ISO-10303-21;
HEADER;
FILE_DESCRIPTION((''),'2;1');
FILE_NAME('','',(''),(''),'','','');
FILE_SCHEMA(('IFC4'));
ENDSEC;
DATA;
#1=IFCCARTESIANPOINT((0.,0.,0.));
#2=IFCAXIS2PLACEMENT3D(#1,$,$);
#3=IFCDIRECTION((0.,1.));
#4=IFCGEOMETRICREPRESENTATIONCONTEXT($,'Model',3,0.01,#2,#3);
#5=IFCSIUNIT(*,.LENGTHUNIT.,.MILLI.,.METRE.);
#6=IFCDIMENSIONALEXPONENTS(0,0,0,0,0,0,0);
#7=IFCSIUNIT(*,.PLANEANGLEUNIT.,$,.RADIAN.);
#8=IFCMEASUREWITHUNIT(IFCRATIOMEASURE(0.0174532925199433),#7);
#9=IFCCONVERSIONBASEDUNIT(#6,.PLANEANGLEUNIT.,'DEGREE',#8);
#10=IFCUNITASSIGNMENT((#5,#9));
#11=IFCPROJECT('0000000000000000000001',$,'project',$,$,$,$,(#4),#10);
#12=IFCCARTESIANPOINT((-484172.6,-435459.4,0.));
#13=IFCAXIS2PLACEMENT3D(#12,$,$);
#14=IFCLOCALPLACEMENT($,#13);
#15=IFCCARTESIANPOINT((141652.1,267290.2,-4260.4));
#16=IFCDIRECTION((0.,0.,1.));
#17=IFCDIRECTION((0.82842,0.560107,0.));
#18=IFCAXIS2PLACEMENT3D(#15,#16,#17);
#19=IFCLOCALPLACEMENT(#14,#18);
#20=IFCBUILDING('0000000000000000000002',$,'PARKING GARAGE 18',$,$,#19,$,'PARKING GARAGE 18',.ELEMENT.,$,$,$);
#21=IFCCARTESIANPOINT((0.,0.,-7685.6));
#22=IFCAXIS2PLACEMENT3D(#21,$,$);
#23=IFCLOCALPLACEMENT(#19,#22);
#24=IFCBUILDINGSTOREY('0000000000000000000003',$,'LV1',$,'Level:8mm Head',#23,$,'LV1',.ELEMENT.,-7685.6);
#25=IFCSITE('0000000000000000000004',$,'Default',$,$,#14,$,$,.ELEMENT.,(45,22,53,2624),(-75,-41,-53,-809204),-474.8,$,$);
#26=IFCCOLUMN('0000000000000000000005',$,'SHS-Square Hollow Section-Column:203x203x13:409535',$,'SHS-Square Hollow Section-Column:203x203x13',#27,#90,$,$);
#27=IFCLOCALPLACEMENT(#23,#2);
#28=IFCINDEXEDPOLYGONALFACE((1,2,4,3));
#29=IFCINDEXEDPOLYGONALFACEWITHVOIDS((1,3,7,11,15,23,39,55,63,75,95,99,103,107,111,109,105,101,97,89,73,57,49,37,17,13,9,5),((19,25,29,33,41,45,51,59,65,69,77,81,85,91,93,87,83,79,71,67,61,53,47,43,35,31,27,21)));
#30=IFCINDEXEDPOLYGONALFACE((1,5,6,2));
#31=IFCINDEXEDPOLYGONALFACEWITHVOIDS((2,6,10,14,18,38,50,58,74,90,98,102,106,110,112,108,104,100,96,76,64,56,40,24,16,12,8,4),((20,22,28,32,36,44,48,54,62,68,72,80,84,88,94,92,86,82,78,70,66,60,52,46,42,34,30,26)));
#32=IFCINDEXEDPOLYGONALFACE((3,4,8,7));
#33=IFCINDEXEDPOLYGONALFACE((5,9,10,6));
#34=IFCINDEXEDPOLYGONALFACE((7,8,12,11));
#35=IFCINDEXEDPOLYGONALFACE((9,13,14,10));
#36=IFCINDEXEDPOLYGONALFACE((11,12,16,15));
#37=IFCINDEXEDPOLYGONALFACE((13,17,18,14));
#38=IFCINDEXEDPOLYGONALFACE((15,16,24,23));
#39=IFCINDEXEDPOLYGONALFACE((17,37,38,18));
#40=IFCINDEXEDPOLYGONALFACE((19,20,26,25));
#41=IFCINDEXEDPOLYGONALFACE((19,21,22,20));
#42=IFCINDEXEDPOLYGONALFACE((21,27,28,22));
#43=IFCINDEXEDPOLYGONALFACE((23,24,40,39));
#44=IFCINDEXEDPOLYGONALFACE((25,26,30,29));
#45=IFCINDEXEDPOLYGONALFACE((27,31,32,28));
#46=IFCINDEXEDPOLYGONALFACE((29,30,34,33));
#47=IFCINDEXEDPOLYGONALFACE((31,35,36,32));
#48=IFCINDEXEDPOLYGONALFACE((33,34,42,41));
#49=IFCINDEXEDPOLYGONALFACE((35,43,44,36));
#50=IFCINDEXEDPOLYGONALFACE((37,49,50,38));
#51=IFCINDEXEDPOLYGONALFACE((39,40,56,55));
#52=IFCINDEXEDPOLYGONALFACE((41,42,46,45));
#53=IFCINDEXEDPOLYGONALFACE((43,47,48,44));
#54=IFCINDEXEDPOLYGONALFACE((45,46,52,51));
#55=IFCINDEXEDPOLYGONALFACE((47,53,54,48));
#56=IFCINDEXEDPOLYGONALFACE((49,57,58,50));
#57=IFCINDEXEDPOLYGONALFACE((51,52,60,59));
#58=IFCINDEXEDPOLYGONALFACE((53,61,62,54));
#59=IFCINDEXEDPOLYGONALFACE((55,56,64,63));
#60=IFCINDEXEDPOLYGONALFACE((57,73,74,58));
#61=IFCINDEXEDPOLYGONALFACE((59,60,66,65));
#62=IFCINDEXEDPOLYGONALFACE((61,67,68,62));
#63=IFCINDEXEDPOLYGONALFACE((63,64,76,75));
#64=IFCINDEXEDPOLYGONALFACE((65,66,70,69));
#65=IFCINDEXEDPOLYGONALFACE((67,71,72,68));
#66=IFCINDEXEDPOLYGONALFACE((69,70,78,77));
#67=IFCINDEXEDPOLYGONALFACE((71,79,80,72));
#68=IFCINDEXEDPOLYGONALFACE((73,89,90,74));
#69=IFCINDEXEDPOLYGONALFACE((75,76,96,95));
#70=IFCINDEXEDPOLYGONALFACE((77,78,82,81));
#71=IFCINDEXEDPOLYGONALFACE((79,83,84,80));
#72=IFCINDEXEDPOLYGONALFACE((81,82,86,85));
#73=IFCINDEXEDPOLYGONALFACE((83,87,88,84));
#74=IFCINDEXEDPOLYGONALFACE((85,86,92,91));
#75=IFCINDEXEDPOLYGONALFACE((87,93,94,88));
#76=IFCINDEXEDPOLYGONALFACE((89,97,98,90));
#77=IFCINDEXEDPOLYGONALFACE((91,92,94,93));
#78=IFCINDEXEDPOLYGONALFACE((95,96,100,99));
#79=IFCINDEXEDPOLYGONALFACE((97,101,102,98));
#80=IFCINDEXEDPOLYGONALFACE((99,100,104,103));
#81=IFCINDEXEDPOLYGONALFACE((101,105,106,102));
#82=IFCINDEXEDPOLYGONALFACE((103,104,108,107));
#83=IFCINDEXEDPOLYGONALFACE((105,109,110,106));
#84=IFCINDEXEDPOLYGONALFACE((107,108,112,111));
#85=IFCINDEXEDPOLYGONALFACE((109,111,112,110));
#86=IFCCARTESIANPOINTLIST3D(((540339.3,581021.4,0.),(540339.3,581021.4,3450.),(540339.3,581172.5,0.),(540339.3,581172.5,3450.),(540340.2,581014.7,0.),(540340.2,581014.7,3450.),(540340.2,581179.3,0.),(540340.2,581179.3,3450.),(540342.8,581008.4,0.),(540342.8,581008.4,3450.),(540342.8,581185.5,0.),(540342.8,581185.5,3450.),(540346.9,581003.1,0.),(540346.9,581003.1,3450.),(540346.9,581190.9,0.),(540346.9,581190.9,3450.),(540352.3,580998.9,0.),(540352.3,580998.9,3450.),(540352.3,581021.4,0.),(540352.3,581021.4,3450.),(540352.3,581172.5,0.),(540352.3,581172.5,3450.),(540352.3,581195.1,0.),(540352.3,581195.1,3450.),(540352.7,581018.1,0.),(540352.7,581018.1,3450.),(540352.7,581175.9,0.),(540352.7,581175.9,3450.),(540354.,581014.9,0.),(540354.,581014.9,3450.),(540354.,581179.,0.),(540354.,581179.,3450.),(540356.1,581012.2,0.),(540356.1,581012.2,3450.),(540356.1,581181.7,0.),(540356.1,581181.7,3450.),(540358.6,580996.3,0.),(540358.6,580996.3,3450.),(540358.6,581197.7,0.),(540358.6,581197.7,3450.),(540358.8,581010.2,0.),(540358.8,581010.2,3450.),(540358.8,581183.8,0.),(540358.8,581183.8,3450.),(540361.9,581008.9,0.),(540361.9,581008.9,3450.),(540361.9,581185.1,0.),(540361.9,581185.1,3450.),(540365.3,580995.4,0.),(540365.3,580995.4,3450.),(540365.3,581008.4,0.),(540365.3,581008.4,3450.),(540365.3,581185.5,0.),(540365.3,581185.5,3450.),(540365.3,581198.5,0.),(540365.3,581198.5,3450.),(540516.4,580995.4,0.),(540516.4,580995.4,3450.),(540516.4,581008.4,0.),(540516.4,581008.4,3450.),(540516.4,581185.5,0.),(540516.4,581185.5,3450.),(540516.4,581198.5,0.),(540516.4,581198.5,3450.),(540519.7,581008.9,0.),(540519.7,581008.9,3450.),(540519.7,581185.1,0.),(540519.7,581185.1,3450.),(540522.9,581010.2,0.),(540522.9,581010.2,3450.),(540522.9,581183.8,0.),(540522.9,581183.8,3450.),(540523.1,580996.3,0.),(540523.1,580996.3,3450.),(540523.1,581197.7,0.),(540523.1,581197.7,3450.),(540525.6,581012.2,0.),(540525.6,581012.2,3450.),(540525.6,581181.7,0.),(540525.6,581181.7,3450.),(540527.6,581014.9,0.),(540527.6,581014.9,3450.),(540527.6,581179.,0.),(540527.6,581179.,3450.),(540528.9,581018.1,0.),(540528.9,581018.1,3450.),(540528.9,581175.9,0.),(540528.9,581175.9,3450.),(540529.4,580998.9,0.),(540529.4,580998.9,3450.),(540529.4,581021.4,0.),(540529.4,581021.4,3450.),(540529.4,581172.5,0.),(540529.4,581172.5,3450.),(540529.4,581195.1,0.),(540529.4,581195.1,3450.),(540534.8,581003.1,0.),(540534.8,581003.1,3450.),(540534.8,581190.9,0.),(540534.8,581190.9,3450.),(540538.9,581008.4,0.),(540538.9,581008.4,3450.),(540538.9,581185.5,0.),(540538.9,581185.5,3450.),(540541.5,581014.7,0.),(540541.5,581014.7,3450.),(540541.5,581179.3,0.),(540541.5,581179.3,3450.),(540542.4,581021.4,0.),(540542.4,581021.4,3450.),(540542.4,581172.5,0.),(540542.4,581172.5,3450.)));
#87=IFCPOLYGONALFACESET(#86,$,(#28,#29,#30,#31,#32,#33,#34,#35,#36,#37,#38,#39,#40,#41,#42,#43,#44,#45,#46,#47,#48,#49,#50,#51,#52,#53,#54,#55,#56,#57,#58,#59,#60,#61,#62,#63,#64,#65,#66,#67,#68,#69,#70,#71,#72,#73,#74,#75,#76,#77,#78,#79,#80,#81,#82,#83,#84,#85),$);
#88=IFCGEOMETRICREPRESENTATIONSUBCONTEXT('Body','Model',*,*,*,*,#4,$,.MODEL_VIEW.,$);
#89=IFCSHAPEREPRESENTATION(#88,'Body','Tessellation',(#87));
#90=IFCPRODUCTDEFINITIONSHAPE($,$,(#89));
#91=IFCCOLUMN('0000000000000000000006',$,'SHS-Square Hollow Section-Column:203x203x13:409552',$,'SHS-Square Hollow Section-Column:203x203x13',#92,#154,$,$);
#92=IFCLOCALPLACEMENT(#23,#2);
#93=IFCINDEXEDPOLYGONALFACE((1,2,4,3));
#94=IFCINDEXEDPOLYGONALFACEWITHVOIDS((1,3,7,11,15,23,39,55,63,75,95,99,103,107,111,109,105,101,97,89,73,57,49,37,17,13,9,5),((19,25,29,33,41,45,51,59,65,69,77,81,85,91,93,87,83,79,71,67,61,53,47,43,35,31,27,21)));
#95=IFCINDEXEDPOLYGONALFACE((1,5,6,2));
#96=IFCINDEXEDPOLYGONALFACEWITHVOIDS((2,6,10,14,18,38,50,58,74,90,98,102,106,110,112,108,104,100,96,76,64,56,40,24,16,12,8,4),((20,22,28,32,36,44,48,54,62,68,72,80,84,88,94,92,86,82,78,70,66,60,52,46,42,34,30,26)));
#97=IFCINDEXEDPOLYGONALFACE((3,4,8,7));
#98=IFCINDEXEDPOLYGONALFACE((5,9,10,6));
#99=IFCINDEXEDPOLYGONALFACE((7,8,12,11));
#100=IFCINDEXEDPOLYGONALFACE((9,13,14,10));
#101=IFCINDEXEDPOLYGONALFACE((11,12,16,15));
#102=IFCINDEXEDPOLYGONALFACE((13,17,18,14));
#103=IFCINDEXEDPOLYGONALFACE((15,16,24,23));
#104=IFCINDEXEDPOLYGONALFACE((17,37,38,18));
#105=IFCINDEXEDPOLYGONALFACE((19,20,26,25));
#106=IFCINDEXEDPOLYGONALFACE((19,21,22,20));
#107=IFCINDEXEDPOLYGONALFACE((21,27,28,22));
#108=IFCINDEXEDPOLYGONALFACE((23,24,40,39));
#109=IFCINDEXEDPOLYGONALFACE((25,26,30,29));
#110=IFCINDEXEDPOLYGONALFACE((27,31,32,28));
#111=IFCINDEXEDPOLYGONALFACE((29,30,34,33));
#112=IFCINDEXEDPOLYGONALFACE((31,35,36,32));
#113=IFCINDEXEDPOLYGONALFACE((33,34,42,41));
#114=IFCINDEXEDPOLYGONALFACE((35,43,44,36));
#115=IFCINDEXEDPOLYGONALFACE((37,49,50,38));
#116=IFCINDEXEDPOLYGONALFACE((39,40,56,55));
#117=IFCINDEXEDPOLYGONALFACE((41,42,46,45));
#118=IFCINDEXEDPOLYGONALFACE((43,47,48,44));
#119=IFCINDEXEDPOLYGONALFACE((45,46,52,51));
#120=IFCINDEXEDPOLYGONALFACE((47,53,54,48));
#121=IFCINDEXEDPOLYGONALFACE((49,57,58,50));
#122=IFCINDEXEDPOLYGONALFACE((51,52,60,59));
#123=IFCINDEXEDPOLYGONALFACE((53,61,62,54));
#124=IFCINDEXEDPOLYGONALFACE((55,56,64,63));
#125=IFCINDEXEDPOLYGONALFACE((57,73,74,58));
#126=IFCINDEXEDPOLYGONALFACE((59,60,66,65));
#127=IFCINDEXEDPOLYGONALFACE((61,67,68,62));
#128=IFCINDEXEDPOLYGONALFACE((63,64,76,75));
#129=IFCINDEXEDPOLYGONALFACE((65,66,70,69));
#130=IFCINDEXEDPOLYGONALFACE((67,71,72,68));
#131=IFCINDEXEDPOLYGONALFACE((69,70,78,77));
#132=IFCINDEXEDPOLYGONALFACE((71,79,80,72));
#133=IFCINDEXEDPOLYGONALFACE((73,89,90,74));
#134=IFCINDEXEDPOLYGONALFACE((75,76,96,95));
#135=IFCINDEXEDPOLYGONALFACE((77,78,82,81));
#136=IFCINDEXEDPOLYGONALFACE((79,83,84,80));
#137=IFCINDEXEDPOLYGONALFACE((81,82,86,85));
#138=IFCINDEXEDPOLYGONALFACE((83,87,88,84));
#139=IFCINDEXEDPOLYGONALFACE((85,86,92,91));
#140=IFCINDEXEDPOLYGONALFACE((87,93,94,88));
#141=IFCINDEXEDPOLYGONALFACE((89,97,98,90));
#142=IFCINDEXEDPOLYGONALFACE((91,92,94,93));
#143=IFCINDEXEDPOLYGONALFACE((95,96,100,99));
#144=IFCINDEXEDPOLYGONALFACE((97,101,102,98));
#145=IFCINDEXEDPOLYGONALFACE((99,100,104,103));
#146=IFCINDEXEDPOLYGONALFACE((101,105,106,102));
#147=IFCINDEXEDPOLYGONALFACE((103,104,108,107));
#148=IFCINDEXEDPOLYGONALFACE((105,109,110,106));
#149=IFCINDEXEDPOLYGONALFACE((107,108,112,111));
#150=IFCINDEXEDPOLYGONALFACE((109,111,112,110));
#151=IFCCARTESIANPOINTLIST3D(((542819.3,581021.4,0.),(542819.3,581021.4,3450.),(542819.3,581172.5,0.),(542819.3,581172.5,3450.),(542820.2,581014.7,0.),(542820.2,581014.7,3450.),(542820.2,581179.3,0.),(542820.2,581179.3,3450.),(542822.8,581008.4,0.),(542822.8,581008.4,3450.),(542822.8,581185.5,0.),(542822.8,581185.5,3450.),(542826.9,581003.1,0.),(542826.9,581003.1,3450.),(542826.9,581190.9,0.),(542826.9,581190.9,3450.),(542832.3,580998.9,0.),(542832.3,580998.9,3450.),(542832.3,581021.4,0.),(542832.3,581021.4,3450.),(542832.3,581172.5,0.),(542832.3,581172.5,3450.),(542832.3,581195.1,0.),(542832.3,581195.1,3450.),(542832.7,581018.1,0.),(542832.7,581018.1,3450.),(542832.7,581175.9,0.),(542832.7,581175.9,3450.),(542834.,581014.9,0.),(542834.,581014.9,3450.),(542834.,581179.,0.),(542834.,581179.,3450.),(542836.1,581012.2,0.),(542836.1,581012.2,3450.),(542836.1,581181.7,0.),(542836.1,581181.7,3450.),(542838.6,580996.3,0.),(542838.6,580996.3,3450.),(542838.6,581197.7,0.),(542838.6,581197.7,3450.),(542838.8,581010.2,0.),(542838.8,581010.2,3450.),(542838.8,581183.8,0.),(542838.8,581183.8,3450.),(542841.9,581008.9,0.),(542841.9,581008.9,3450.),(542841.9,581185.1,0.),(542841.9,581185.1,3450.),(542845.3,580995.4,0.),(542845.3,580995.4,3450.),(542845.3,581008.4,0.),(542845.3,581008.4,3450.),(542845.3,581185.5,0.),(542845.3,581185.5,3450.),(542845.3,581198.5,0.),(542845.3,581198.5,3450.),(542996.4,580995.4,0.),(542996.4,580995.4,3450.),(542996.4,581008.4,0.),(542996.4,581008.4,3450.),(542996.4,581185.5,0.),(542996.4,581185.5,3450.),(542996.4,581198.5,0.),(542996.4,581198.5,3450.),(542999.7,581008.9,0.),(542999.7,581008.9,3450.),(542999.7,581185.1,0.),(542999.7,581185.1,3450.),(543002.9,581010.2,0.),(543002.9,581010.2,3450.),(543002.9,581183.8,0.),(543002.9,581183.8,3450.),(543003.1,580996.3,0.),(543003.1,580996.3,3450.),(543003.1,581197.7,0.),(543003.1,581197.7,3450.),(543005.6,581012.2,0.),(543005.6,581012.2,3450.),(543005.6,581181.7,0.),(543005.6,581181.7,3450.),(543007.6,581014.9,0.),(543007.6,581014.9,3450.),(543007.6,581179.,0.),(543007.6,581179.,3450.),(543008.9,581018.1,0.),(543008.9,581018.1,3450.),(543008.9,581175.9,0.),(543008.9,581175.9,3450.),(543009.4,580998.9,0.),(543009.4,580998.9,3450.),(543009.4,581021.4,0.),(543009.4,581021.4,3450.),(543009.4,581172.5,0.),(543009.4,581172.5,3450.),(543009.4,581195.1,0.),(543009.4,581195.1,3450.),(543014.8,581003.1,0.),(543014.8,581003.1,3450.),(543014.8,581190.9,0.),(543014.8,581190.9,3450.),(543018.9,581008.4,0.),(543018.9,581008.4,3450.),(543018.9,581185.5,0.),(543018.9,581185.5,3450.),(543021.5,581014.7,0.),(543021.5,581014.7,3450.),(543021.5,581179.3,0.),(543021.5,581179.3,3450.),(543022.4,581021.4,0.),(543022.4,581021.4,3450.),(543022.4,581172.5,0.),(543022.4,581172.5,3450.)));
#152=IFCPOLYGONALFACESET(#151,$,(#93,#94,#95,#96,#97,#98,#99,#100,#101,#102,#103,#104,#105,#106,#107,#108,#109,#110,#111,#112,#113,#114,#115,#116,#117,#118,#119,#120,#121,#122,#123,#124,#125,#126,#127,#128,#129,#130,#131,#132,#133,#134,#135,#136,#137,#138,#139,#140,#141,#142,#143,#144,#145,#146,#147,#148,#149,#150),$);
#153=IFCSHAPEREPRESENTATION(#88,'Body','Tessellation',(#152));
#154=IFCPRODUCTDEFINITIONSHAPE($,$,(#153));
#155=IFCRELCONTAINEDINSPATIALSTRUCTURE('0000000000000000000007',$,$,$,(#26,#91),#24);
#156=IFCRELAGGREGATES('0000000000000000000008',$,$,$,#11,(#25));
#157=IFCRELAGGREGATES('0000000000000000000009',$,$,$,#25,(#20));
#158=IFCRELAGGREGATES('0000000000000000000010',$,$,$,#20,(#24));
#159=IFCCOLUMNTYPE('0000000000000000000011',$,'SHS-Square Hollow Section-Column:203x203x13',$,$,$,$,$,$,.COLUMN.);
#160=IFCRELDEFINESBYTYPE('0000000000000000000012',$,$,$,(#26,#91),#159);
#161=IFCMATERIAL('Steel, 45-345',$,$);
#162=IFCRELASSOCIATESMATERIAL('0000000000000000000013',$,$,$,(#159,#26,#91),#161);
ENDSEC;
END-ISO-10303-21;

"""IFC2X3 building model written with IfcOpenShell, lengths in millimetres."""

from ifc_helpers import new_model, entity, si_unit, converted_unit, direction, frame, frame_2d, origin, place, context, subcontext, project, spatial, polyline, circle_curve, parameter, trimmed, segment, composite_curve, outline, extrude, source, transform, mapped, material, type_object, type_shapes, element, save


model = new_model("IFC2X3")

# Units and contexts
model_context = context("Model", 3, precision=0.01, world=origin(), true_north=direction((0.0, 1.0)))
body_context = subcontext(model_context, "Body", "Model", "MODEL_VIEW")
ifc_project = project(units=[si_unit("LENGTHUNIT", "METRE", prefix="MILLI"), converted_unit("PLANEANGLEUNIT", "DEGREE", entity("IfcRatioMeasure", 0.0174532925199433), si_unit("PLANEANGLEUNIT", "RADIAN"), dimensions=[0, 0, 0, 0, 0, 0, 0])], contexts=[model_context])

# Site, building, storey
site_placement = place(None, frame((-484172.6, -435459.4, 0.0)))
site = spatial("IfcSite", under=ifc_project, at=site_placement, Name="Default", CompositionType="ELEMENT", RefLatitude=(45, 22, 53, 2624), RefLongitude=(-75, -41, -53, -809204), RefElevation=-474.8)
building_placement = place(site_placement, frame((141652.1, 267290.2, -4260.4), z_axis=(0.0, 0.0, 1.0), x_axis=(0.82842, 0.560107, 0.0)))
building = spatial("IfcBuilding", under=site, at=building_placement, Name="PARKING GARAGE 18", LongName="PARKING GARAGE 18", CompositionType="ELEMENT")
storey_placement = place(building_placement, frame((0.0, 0.0, -7685.6)))
storey = spatial("IfcBuildingStorey", under=building, at=storey_placement, Name="LV1", ObjectType="Level:8mm Head", LongName="LV1", CompositionType="ELEMENT", Elevation=-7685.6)

# Columns
ifc_material_1 = material(Name="Steel, 45-345")
column_type = type_object("IfcColumnType", Name="SHS-Square Hollow Section-Column:203x203x13", PredefinedType="COLUMN", material=ifc_material_1)
shared_shape_1 = source(origin(), body_context, "Body", "SweptSolid", [
    extrude(outline(composite_curve([segment(polyline([(-75.6, -101.5), (75.6, -101.5)]), True, "CONTINUOUS"), segment(trimmed(circle_curve(frame_2d((75.6, -75.6), x_axis=(-1.0, 0.0)), 26.0), [parameter(90.0)], [parameter(180.0)], True, "PARAMETER"), True, "CONTINUOUS"), segment(polyline([(101.5, -75.6), (101.5, 75.6)]), True, "CONTINUOUS"), segment(trimmed(circle_curve(frame_2d((75.5, 75.6), x_axis=(-1.0, 0.0)), 26.0), [parameter(180.0)], [parameter(270.0)], True, "PARAMETER"), True, "CONTINUOUS"), segment(polyline([(75.5, 101.6), (-75.5, 101.6)]), True, "CONTINUOUS"), segment(trimmed(circle_curve(frame_2d((-75.5, 75.5), x_axis=(-1.0, 0.0)), 26.0), [parameter(270.0)], [parameter(360.0)], True, "PARAMETER"), True, "CONTINUOUS"), segment(polyline([(-101.5, 75.5), (-101.5, -75.6)]), True, "CONTINUOUS"), segment(trimmed(circle_curve(frame_2d((-75.6, -75.6), x_axis=(-1.0, 0.0)), 26.0), [parameter(360.0)], [parameter(90.0)], True, "PARAMETER"), True, "CONTINUOUS")], self_intersect=False), holes=[composite_curve([segment(trimmed(circle_curve(frame_2d((-75.6, -75.6), x_axis=(-1.0, 0.0)), 13.0), [parameter(0.0)], [parameter(90.0)], True, "PARAMETER"), False, "CONTINUOUS"), segment(polyline([(-88.5, -75.6), (-88.5, 75.6)]), True, "CONTINUOUS"), segment(trimmed(circle_curve(frame_2d((-75.6, 75.6), x_axis=(-1.0, 0.0)), 13.0), [parameter(270.0)], [parameter(0.0)], True, "PARAMETER"), False, "CONTINUOUS"), segment(polyline([(-75.6, 88.6), (75.5, 88.6)]), True, "CONTINUOUS"), segment(trimmed(circle_curve(frame_2d((75.5, 75.5), x_axis=(-1.0, 0.0)), 13.0), [parameter(180.0)], [parameter(270.0)], True, "PARAMETER"), False, "CONTINUOUS"), segment(polyline([(88.6, 75.5), (88.6, -75.5)]), True, "CONTINUOUS"), segment(trimmed(circle_curve(frame_2d((75.6, -75.5), x_axis=(-1.0, 0.0)), 13.0), [parameter(90.0)], [parameter(180.0)], True, "PARAMETER"), False, "CONTINUOUS"), segment(polyline([(75.6, -88.5), (-75.6, -88.5)]), True, "CONTINUOUS")], self_intersect=False)]), frame((0.0, 0.0, -7685.6), z_axis=(0.0, 0.0, 1.0), x_axis=(-1.0, 0.0, 0.0)), (0.0, 0.0, 1.0), 3450.0),
])
type_shapes(column_type, [shared_shape_1])
for number, where, name in (
    (1, (540440.8, 581097.0, 7685.6), "SHS-Square Hollow Section-Column:203x203x13:409535"),
    (2, (542920.8, 581097.0, 7685.6), "SHS-Square Hollow Section-Column:203x203x13:409552"),
):
    element("IfcColumn", number, at=place(storey_placement, frame(where)), inside=storey, type_object=column_type, material=ifc_material_1, Name=name, ObjectType="SHS-Square Hollow Section-Column:203x203x13", context=body_context, shape_type="MappedRepresentation", body=[
        mapped(shared_shape_1, transform((0.0, 0.0, 0.0), scale=1.0)),
    ])

save(model, "model.ifc")
